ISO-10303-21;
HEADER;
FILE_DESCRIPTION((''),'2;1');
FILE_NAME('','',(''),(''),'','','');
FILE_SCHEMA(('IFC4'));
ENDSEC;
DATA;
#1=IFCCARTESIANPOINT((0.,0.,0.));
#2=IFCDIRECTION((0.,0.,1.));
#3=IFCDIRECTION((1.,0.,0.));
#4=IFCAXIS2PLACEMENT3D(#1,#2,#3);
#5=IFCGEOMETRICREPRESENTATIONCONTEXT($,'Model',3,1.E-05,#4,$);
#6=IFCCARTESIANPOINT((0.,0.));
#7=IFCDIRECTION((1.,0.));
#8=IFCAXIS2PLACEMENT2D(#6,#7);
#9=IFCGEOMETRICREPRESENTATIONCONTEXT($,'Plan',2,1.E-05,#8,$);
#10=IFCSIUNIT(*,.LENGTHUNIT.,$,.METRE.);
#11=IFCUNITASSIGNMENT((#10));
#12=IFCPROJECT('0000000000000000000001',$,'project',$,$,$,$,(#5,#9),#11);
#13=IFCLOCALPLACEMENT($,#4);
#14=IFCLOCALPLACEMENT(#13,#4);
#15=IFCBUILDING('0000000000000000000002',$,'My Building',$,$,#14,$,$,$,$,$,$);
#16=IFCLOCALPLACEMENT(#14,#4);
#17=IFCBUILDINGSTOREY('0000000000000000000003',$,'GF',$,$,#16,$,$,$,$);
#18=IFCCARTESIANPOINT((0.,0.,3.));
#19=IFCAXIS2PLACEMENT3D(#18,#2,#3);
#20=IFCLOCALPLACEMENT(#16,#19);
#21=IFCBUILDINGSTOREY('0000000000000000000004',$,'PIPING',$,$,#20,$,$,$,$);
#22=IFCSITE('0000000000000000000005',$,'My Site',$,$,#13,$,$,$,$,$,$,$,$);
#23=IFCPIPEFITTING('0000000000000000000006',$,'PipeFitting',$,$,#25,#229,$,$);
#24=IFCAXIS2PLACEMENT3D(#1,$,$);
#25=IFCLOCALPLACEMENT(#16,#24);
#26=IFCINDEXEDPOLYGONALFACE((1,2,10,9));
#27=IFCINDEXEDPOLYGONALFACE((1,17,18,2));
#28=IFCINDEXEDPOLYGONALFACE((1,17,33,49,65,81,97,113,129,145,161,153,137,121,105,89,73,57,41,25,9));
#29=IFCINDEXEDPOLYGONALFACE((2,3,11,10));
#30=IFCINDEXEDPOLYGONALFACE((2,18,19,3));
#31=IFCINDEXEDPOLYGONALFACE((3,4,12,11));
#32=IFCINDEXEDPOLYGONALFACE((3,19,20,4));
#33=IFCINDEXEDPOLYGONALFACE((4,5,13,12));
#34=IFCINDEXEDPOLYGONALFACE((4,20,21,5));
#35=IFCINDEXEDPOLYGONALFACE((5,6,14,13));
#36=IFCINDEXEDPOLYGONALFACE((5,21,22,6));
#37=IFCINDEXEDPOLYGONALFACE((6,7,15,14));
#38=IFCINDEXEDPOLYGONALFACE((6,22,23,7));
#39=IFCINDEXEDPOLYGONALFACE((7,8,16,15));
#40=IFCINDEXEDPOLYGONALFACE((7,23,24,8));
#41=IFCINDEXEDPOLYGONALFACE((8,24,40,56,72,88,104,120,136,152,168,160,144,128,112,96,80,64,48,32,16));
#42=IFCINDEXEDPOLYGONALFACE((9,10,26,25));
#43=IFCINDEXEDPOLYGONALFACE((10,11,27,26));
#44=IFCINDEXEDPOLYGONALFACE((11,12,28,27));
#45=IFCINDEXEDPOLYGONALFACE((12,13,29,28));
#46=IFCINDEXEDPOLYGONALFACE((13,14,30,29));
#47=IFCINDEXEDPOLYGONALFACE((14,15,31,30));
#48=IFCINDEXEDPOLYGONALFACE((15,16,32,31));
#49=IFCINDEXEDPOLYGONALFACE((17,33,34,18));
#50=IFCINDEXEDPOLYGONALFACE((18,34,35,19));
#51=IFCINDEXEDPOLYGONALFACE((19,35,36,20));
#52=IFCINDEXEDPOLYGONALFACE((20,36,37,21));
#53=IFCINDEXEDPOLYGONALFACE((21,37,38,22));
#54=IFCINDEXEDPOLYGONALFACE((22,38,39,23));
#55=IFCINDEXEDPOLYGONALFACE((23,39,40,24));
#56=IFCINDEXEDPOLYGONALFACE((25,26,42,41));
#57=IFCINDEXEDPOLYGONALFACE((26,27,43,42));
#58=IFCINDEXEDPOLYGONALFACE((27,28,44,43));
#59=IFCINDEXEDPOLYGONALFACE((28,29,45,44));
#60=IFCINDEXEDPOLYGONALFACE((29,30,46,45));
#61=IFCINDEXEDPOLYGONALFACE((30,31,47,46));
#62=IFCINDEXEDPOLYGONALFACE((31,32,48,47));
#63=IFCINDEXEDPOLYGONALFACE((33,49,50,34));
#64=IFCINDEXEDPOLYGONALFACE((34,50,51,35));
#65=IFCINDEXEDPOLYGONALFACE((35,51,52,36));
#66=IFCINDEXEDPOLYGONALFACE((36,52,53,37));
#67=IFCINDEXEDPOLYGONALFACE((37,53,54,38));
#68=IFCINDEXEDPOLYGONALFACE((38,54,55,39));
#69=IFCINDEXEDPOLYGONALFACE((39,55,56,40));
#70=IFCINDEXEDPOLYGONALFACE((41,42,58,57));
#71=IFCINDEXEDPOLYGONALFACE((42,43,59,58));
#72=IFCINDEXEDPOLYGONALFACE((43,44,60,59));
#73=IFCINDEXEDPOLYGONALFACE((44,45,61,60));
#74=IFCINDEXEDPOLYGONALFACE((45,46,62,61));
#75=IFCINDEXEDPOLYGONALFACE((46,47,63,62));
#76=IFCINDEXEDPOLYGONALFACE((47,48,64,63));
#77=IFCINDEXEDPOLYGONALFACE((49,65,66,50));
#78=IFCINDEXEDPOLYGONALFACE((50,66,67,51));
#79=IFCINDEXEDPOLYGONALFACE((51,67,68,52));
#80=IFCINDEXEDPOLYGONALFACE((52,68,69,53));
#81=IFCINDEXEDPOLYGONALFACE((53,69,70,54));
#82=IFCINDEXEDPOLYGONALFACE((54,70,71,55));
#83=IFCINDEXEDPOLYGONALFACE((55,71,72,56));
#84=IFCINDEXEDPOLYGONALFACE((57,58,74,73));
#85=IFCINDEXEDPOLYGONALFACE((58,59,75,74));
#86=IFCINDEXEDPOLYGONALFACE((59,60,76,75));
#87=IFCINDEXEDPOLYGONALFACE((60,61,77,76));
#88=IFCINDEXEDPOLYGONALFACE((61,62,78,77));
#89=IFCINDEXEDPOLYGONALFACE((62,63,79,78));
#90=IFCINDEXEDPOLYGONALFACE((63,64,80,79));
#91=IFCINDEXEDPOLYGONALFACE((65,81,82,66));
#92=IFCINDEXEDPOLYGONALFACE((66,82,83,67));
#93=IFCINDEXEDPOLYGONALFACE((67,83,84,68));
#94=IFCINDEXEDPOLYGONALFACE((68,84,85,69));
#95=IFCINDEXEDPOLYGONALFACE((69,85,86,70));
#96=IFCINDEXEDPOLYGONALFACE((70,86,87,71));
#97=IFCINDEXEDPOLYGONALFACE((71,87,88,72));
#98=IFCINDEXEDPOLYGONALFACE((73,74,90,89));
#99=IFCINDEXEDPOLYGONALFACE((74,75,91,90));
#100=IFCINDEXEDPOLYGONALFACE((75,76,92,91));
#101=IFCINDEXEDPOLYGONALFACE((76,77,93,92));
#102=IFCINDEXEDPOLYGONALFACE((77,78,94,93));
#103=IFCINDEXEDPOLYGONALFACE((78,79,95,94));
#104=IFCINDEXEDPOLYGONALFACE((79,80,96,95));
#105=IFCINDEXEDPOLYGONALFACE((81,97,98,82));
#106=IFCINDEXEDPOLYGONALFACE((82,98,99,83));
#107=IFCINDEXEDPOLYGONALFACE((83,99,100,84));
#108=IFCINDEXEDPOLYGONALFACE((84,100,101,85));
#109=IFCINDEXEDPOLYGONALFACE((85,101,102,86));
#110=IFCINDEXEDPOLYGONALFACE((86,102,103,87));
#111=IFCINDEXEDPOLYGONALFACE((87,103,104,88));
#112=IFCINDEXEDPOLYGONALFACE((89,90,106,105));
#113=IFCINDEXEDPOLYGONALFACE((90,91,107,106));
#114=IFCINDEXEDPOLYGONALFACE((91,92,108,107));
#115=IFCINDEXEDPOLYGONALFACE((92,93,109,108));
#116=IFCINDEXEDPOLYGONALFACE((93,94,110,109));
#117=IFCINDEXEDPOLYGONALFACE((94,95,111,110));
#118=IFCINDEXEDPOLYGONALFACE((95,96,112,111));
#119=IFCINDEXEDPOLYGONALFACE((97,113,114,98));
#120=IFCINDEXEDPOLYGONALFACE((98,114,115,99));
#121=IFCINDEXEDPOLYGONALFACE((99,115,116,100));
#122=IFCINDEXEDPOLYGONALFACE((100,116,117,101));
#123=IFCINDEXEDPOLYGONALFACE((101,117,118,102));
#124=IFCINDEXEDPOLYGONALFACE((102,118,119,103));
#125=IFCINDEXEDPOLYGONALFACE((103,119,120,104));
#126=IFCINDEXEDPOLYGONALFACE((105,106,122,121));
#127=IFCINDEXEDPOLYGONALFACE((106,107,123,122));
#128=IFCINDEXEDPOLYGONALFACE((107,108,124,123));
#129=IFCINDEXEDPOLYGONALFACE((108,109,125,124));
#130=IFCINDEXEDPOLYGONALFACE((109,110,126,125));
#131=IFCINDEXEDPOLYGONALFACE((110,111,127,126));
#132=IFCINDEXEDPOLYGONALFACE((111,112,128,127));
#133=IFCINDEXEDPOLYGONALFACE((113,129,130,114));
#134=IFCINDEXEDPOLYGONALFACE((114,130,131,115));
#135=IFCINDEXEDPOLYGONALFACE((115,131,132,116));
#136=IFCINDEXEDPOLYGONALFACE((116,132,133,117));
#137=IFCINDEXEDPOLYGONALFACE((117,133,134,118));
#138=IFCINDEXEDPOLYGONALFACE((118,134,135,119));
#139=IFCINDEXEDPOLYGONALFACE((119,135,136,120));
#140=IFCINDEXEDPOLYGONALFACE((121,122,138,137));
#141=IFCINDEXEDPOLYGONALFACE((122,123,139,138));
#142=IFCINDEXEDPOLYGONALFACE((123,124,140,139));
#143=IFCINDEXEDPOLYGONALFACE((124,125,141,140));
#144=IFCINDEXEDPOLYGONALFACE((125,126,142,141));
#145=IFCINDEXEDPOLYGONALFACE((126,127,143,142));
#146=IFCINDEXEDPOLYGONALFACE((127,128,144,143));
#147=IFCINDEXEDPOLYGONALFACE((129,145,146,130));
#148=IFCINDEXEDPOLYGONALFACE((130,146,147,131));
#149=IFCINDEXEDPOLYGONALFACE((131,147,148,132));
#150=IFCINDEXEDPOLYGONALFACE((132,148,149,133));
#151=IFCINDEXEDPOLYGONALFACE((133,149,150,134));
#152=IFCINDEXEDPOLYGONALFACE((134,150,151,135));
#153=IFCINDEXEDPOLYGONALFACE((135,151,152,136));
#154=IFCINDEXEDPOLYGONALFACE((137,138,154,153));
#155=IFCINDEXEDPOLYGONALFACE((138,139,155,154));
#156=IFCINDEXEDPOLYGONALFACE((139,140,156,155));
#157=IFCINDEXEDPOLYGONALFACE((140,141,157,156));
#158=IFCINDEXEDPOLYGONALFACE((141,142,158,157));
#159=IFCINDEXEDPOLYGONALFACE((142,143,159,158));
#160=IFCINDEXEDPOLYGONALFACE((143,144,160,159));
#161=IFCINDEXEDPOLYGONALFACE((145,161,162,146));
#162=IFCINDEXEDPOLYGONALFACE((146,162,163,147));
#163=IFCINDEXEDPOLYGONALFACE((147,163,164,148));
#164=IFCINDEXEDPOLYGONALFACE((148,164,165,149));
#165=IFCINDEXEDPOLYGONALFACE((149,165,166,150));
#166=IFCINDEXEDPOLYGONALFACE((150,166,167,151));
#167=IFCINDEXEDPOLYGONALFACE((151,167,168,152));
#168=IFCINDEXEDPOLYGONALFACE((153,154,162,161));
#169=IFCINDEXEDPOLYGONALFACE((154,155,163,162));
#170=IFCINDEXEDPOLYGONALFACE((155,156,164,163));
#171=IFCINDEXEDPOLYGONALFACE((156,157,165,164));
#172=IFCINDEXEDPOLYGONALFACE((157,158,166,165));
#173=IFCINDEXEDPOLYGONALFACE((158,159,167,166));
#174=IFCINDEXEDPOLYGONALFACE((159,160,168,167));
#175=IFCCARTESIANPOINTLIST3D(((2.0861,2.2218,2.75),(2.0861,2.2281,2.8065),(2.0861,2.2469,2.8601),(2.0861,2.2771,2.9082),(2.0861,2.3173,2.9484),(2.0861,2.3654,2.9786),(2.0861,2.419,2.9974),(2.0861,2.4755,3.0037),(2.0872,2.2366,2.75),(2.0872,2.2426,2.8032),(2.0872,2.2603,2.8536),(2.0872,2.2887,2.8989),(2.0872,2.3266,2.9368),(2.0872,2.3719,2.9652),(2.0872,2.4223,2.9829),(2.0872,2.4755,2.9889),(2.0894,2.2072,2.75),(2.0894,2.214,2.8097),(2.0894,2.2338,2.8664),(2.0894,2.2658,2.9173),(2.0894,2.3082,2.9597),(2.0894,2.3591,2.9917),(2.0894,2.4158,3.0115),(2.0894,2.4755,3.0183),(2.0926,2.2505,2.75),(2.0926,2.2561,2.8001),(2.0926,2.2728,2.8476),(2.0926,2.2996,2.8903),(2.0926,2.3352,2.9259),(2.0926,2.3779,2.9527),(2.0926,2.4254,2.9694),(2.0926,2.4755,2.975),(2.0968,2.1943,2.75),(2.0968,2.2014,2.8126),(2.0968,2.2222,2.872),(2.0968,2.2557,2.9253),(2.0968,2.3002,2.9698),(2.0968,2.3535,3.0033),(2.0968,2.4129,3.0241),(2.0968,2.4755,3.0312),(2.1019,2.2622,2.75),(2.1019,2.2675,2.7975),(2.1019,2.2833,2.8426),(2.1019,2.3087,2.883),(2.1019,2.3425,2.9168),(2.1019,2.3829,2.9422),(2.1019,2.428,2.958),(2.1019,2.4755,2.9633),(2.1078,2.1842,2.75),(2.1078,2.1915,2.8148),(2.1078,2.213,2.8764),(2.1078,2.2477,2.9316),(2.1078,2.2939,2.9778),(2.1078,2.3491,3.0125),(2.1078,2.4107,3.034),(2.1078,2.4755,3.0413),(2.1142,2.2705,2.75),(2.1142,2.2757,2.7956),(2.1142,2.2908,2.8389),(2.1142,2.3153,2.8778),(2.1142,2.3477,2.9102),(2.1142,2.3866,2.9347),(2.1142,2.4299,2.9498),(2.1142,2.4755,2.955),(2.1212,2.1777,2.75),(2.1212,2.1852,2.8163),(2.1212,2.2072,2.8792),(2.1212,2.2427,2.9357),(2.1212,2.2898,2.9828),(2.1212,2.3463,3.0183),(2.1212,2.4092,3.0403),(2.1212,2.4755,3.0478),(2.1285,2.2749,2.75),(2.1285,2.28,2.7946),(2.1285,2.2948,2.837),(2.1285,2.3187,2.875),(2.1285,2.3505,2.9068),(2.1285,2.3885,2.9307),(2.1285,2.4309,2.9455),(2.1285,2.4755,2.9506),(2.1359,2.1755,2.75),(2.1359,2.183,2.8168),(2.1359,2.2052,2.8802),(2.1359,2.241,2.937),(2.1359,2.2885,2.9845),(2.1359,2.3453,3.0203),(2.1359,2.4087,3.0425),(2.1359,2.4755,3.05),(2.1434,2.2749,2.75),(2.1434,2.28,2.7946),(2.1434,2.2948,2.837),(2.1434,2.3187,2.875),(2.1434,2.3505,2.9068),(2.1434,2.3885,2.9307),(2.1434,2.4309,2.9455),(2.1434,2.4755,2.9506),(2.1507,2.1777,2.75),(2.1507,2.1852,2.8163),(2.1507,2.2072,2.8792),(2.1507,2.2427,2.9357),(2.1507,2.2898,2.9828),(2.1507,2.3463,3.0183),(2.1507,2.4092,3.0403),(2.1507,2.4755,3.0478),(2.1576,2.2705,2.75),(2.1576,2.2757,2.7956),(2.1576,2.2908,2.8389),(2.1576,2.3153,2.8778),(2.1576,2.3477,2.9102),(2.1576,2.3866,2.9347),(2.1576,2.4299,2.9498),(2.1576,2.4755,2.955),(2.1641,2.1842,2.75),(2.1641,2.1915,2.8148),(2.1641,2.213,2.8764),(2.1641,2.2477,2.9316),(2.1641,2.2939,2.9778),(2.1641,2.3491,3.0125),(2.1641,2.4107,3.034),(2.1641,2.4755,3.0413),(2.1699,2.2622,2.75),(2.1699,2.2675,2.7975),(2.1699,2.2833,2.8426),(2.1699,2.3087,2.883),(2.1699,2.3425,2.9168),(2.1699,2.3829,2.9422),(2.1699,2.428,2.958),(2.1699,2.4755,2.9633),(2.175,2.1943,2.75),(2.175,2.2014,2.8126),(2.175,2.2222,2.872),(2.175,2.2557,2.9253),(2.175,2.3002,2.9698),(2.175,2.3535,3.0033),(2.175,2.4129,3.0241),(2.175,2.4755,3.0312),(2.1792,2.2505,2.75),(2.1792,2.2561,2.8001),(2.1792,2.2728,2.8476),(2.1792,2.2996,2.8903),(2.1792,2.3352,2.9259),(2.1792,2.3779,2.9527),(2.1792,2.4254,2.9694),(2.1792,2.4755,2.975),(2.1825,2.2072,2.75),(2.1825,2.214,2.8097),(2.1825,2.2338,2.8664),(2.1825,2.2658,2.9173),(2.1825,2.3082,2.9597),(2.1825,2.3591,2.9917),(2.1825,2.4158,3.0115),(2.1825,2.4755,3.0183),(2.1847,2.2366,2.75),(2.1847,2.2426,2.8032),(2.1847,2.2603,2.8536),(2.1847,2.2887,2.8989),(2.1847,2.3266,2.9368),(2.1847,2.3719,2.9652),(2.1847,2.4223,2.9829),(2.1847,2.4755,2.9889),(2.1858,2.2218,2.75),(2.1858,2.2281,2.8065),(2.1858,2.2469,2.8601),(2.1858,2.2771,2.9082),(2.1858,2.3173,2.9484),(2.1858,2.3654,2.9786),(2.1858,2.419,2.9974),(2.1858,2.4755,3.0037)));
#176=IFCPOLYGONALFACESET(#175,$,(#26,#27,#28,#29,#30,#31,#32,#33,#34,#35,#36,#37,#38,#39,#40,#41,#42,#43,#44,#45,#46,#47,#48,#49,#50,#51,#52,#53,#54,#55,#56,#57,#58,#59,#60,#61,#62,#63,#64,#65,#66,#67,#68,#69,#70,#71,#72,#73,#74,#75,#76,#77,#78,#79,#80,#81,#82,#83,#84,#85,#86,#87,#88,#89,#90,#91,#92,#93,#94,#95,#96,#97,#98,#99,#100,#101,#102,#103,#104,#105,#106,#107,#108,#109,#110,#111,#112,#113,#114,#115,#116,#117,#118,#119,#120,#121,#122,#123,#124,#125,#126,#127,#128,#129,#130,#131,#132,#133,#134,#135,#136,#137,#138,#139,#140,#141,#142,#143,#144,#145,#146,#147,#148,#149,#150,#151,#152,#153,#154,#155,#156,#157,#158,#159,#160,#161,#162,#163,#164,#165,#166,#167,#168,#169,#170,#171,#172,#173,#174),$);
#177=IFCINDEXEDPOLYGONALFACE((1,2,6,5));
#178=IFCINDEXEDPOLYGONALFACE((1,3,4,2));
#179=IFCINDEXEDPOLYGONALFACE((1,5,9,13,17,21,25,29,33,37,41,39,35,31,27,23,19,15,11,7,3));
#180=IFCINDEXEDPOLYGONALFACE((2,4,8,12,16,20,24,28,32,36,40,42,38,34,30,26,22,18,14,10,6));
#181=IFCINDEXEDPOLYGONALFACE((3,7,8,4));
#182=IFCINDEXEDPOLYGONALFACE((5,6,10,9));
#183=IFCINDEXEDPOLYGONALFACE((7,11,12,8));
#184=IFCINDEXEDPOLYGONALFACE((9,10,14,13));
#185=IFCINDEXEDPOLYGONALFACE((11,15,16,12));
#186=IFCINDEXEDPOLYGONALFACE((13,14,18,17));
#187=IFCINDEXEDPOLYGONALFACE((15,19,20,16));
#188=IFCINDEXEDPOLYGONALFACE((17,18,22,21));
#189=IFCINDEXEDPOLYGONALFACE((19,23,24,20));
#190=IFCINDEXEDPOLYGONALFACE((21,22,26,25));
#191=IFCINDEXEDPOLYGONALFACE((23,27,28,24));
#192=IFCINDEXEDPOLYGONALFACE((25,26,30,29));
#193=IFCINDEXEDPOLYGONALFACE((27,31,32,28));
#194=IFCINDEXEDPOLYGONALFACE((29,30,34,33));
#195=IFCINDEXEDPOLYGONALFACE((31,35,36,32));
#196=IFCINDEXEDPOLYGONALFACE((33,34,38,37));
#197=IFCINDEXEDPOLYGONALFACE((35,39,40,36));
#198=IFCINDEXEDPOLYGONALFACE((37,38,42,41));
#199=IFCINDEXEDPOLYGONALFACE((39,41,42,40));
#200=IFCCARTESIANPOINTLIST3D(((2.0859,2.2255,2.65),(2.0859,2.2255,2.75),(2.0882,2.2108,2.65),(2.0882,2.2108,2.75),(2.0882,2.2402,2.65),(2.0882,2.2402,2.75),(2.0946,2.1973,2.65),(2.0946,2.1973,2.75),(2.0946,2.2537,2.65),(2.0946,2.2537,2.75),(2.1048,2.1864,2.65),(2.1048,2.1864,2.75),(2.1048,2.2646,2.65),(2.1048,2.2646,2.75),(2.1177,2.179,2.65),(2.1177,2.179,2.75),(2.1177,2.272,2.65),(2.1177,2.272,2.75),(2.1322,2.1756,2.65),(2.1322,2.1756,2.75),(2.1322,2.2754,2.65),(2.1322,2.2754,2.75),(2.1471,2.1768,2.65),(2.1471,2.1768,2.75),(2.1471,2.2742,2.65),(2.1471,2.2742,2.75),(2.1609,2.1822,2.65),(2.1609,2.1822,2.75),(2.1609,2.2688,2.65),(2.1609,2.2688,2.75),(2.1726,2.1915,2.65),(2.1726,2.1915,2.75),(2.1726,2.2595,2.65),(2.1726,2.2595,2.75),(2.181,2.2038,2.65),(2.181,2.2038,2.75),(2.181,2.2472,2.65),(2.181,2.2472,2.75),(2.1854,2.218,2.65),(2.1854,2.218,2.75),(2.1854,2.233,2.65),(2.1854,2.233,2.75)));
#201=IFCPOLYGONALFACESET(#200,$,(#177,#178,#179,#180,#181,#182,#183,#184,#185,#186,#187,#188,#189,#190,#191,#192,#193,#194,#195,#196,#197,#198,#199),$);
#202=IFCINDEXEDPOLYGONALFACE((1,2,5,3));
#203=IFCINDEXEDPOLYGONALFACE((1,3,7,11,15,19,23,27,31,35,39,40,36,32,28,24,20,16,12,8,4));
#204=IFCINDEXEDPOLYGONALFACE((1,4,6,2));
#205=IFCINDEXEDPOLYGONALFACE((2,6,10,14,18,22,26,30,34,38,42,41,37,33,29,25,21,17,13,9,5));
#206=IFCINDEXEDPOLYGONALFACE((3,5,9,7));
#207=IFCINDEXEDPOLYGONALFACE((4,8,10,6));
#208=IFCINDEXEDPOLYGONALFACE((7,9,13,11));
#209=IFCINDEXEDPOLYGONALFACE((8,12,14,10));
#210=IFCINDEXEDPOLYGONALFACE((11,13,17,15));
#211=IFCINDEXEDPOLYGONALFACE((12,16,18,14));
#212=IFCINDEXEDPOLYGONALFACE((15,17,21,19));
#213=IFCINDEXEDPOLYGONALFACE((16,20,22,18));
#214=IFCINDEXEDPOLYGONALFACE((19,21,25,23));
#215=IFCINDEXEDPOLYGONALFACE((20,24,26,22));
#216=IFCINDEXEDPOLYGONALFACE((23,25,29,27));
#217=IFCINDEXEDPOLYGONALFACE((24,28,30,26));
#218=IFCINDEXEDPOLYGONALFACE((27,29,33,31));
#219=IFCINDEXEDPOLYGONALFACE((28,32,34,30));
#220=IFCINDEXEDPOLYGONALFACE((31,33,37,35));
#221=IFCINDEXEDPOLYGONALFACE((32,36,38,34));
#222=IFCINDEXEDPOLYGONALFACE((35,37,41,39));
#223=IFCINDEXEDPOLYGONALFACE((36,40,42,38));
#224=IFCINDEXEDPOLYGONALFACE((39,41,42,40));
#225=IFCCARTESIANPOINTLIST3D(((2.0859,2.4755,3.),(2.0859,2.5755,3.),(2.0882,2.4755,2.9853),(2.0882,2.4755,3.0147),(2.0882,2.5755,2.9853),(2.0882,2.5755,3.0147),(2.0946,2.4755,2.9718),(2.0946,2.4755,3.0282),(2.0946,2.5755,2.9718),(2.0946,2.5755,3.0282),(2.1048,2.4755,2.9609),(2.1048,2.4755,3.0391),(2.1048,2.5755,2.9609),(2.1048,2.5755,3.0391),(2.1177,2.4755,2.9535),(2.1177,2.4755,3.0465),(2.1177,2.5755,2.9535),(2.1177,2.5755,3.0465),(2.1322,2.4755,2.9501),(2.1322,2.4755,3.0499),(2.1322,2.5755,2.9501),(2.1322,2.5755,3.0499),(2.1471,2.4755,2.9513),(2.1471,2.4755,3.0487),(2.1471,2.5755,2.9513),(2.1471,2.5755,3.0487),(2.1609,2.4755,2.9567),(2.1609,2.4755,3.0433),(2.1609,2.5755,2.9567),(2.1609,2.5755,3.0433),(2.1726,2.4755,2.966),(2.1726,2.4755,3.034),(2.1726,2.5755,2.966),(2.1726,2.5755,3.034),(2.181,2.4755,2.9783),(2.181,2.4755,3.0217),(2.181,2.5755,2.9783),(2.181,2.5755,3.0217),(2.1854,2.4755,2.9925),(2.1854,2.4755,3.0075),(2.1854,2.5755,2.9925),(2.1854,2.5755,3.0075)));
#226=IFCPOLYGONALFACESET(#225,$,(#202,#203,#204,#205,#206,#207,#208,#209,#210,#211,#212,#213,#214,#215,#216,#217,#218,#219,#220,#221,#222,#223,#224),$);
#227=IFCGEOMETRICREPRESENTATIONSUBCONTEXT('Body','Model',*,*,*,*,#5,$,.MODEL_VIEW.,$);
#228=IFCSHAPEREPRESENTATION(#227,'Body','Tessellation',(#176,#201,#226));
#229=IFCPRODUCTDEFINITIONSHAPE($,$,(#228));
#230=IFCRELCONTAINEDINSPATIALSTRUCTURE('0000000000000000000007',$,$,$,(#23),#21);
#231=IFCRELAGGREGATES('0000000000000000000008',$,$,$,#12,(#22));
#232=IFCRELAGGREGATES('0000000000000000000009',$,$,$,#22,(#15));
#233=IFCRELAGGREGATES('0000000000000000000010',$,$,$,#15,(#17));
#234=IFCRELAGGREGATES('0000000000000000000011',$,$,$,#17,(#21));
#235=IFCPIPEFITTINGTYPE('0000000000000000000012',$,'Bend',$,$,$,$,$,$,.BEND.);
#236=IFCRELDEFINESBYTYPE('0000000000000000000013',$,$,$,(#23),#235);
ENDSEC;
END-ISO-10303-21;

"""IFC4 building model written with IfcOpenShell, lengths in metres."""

from ifc_helpers import new_model, entity, si_unit, frame, origin_with_axes, origin_2d_with_axis, place, context, subcontext, project, spatial, circle, extrude, source, transform, mapped, type_object, type_shapes, element, save


model = new_model("IFC4")

# Units and contexts
model_context = context("Model", 3, precision=1e-05, world=origin_with_axes())
plan_context = context("Plan", 2, precision=1e-05, world=origin_2d_with_axis())
body_context = subcontext(model_context, "Body", "Model", "MODEL_VIEW")
ifc_project = project(units=[si_unit("LENGTHUNIT", "METRE")], contexts=[model_context, plan_context])

# Site, building, storeys
site_placement = place(None, origin_with_axes())
site = spatial("IfcSite", under=ifc_project, at=site_placement, Name="My Site")
building_placement = place(site_placement, origin_with_axes())
building = spatial("IfcBuilding", under=site, at=building_placement, Name="My Building")
storey_1_placement = place(building_placement, origin_with_axes())
storey_1 = spatial("IfcBuildingStorey", under=building, at=storey_1_placement, Name="GF")
storey_2_placement = place(storey_1_placement, frame((0.0, 0.0, 3.0), z_axis=(0.0, 0.0, 1.0), x_axis=(1.0, 0.0, 0.0)))
storey_2 = spatial("IfcBuildingStorey", under=storey_1, at=storey_2_placement, Name="PIPING")

# Pipe fitting
pipe_fitting_type = type_object("IfcPipeFittingType", Name="Bend", PredefinedType="BEND")
shared_shape = source(origin_with_axes(), body_context, "Body", "SolidModel", [
    entity("IfcSweptDiskSolid", entity("IfcIndexedPolyCurve", entity("IfcCartesianPointList3D", [[0.0, 0.0, -0.1], [0.0, 0.0732, -0.2768], [0.0, 0.25, -0.35]]), [entity("IfcArcIndex", [1, 2, 3])]), 0.05),
    extrude(circle(Radius=0.05), origin_with_axes(), (0.0, 0.0, -1.0), 0.1),
    extrude(circle(Radius=0.05), frame((0.0, 0.25, -0.35), z_axis=(0.0, 1.0, 0.0), x_axis=(1.0, 0.0, 0.0)), (0.0, 0.0, 1.0), 0.1),
])
type_shapes(pipe_fitting_type, [shared_shape])
for number, where, z_axis, x_axis, name in (
    (1, (2.1359, 2.2255, -0.35), (0.0, 0.0, -1.0), (-1.0, 0.0, 0.0), "PipeFitting"),
):
    element("IfcPipeFitting", number, at=place(storey_2_placement, frame(where, z_axis=z_axis, x_axis=x_axis)), inside=storey_2, type_object=pipe_fitting_type, Name=name, context=body_context, shape_type="MappedRepresentation", body=[
        mapped(shared_shape, transform((0.0, 0.0, 0.0), x_axis=(1.0, 0.0, 0.0), y_axis=(0.0, 1.0, 0.0), z_axis=(0.0, 0.0, 1.0), scale=1.0)),
    ])

save(model, "model.ifc")
